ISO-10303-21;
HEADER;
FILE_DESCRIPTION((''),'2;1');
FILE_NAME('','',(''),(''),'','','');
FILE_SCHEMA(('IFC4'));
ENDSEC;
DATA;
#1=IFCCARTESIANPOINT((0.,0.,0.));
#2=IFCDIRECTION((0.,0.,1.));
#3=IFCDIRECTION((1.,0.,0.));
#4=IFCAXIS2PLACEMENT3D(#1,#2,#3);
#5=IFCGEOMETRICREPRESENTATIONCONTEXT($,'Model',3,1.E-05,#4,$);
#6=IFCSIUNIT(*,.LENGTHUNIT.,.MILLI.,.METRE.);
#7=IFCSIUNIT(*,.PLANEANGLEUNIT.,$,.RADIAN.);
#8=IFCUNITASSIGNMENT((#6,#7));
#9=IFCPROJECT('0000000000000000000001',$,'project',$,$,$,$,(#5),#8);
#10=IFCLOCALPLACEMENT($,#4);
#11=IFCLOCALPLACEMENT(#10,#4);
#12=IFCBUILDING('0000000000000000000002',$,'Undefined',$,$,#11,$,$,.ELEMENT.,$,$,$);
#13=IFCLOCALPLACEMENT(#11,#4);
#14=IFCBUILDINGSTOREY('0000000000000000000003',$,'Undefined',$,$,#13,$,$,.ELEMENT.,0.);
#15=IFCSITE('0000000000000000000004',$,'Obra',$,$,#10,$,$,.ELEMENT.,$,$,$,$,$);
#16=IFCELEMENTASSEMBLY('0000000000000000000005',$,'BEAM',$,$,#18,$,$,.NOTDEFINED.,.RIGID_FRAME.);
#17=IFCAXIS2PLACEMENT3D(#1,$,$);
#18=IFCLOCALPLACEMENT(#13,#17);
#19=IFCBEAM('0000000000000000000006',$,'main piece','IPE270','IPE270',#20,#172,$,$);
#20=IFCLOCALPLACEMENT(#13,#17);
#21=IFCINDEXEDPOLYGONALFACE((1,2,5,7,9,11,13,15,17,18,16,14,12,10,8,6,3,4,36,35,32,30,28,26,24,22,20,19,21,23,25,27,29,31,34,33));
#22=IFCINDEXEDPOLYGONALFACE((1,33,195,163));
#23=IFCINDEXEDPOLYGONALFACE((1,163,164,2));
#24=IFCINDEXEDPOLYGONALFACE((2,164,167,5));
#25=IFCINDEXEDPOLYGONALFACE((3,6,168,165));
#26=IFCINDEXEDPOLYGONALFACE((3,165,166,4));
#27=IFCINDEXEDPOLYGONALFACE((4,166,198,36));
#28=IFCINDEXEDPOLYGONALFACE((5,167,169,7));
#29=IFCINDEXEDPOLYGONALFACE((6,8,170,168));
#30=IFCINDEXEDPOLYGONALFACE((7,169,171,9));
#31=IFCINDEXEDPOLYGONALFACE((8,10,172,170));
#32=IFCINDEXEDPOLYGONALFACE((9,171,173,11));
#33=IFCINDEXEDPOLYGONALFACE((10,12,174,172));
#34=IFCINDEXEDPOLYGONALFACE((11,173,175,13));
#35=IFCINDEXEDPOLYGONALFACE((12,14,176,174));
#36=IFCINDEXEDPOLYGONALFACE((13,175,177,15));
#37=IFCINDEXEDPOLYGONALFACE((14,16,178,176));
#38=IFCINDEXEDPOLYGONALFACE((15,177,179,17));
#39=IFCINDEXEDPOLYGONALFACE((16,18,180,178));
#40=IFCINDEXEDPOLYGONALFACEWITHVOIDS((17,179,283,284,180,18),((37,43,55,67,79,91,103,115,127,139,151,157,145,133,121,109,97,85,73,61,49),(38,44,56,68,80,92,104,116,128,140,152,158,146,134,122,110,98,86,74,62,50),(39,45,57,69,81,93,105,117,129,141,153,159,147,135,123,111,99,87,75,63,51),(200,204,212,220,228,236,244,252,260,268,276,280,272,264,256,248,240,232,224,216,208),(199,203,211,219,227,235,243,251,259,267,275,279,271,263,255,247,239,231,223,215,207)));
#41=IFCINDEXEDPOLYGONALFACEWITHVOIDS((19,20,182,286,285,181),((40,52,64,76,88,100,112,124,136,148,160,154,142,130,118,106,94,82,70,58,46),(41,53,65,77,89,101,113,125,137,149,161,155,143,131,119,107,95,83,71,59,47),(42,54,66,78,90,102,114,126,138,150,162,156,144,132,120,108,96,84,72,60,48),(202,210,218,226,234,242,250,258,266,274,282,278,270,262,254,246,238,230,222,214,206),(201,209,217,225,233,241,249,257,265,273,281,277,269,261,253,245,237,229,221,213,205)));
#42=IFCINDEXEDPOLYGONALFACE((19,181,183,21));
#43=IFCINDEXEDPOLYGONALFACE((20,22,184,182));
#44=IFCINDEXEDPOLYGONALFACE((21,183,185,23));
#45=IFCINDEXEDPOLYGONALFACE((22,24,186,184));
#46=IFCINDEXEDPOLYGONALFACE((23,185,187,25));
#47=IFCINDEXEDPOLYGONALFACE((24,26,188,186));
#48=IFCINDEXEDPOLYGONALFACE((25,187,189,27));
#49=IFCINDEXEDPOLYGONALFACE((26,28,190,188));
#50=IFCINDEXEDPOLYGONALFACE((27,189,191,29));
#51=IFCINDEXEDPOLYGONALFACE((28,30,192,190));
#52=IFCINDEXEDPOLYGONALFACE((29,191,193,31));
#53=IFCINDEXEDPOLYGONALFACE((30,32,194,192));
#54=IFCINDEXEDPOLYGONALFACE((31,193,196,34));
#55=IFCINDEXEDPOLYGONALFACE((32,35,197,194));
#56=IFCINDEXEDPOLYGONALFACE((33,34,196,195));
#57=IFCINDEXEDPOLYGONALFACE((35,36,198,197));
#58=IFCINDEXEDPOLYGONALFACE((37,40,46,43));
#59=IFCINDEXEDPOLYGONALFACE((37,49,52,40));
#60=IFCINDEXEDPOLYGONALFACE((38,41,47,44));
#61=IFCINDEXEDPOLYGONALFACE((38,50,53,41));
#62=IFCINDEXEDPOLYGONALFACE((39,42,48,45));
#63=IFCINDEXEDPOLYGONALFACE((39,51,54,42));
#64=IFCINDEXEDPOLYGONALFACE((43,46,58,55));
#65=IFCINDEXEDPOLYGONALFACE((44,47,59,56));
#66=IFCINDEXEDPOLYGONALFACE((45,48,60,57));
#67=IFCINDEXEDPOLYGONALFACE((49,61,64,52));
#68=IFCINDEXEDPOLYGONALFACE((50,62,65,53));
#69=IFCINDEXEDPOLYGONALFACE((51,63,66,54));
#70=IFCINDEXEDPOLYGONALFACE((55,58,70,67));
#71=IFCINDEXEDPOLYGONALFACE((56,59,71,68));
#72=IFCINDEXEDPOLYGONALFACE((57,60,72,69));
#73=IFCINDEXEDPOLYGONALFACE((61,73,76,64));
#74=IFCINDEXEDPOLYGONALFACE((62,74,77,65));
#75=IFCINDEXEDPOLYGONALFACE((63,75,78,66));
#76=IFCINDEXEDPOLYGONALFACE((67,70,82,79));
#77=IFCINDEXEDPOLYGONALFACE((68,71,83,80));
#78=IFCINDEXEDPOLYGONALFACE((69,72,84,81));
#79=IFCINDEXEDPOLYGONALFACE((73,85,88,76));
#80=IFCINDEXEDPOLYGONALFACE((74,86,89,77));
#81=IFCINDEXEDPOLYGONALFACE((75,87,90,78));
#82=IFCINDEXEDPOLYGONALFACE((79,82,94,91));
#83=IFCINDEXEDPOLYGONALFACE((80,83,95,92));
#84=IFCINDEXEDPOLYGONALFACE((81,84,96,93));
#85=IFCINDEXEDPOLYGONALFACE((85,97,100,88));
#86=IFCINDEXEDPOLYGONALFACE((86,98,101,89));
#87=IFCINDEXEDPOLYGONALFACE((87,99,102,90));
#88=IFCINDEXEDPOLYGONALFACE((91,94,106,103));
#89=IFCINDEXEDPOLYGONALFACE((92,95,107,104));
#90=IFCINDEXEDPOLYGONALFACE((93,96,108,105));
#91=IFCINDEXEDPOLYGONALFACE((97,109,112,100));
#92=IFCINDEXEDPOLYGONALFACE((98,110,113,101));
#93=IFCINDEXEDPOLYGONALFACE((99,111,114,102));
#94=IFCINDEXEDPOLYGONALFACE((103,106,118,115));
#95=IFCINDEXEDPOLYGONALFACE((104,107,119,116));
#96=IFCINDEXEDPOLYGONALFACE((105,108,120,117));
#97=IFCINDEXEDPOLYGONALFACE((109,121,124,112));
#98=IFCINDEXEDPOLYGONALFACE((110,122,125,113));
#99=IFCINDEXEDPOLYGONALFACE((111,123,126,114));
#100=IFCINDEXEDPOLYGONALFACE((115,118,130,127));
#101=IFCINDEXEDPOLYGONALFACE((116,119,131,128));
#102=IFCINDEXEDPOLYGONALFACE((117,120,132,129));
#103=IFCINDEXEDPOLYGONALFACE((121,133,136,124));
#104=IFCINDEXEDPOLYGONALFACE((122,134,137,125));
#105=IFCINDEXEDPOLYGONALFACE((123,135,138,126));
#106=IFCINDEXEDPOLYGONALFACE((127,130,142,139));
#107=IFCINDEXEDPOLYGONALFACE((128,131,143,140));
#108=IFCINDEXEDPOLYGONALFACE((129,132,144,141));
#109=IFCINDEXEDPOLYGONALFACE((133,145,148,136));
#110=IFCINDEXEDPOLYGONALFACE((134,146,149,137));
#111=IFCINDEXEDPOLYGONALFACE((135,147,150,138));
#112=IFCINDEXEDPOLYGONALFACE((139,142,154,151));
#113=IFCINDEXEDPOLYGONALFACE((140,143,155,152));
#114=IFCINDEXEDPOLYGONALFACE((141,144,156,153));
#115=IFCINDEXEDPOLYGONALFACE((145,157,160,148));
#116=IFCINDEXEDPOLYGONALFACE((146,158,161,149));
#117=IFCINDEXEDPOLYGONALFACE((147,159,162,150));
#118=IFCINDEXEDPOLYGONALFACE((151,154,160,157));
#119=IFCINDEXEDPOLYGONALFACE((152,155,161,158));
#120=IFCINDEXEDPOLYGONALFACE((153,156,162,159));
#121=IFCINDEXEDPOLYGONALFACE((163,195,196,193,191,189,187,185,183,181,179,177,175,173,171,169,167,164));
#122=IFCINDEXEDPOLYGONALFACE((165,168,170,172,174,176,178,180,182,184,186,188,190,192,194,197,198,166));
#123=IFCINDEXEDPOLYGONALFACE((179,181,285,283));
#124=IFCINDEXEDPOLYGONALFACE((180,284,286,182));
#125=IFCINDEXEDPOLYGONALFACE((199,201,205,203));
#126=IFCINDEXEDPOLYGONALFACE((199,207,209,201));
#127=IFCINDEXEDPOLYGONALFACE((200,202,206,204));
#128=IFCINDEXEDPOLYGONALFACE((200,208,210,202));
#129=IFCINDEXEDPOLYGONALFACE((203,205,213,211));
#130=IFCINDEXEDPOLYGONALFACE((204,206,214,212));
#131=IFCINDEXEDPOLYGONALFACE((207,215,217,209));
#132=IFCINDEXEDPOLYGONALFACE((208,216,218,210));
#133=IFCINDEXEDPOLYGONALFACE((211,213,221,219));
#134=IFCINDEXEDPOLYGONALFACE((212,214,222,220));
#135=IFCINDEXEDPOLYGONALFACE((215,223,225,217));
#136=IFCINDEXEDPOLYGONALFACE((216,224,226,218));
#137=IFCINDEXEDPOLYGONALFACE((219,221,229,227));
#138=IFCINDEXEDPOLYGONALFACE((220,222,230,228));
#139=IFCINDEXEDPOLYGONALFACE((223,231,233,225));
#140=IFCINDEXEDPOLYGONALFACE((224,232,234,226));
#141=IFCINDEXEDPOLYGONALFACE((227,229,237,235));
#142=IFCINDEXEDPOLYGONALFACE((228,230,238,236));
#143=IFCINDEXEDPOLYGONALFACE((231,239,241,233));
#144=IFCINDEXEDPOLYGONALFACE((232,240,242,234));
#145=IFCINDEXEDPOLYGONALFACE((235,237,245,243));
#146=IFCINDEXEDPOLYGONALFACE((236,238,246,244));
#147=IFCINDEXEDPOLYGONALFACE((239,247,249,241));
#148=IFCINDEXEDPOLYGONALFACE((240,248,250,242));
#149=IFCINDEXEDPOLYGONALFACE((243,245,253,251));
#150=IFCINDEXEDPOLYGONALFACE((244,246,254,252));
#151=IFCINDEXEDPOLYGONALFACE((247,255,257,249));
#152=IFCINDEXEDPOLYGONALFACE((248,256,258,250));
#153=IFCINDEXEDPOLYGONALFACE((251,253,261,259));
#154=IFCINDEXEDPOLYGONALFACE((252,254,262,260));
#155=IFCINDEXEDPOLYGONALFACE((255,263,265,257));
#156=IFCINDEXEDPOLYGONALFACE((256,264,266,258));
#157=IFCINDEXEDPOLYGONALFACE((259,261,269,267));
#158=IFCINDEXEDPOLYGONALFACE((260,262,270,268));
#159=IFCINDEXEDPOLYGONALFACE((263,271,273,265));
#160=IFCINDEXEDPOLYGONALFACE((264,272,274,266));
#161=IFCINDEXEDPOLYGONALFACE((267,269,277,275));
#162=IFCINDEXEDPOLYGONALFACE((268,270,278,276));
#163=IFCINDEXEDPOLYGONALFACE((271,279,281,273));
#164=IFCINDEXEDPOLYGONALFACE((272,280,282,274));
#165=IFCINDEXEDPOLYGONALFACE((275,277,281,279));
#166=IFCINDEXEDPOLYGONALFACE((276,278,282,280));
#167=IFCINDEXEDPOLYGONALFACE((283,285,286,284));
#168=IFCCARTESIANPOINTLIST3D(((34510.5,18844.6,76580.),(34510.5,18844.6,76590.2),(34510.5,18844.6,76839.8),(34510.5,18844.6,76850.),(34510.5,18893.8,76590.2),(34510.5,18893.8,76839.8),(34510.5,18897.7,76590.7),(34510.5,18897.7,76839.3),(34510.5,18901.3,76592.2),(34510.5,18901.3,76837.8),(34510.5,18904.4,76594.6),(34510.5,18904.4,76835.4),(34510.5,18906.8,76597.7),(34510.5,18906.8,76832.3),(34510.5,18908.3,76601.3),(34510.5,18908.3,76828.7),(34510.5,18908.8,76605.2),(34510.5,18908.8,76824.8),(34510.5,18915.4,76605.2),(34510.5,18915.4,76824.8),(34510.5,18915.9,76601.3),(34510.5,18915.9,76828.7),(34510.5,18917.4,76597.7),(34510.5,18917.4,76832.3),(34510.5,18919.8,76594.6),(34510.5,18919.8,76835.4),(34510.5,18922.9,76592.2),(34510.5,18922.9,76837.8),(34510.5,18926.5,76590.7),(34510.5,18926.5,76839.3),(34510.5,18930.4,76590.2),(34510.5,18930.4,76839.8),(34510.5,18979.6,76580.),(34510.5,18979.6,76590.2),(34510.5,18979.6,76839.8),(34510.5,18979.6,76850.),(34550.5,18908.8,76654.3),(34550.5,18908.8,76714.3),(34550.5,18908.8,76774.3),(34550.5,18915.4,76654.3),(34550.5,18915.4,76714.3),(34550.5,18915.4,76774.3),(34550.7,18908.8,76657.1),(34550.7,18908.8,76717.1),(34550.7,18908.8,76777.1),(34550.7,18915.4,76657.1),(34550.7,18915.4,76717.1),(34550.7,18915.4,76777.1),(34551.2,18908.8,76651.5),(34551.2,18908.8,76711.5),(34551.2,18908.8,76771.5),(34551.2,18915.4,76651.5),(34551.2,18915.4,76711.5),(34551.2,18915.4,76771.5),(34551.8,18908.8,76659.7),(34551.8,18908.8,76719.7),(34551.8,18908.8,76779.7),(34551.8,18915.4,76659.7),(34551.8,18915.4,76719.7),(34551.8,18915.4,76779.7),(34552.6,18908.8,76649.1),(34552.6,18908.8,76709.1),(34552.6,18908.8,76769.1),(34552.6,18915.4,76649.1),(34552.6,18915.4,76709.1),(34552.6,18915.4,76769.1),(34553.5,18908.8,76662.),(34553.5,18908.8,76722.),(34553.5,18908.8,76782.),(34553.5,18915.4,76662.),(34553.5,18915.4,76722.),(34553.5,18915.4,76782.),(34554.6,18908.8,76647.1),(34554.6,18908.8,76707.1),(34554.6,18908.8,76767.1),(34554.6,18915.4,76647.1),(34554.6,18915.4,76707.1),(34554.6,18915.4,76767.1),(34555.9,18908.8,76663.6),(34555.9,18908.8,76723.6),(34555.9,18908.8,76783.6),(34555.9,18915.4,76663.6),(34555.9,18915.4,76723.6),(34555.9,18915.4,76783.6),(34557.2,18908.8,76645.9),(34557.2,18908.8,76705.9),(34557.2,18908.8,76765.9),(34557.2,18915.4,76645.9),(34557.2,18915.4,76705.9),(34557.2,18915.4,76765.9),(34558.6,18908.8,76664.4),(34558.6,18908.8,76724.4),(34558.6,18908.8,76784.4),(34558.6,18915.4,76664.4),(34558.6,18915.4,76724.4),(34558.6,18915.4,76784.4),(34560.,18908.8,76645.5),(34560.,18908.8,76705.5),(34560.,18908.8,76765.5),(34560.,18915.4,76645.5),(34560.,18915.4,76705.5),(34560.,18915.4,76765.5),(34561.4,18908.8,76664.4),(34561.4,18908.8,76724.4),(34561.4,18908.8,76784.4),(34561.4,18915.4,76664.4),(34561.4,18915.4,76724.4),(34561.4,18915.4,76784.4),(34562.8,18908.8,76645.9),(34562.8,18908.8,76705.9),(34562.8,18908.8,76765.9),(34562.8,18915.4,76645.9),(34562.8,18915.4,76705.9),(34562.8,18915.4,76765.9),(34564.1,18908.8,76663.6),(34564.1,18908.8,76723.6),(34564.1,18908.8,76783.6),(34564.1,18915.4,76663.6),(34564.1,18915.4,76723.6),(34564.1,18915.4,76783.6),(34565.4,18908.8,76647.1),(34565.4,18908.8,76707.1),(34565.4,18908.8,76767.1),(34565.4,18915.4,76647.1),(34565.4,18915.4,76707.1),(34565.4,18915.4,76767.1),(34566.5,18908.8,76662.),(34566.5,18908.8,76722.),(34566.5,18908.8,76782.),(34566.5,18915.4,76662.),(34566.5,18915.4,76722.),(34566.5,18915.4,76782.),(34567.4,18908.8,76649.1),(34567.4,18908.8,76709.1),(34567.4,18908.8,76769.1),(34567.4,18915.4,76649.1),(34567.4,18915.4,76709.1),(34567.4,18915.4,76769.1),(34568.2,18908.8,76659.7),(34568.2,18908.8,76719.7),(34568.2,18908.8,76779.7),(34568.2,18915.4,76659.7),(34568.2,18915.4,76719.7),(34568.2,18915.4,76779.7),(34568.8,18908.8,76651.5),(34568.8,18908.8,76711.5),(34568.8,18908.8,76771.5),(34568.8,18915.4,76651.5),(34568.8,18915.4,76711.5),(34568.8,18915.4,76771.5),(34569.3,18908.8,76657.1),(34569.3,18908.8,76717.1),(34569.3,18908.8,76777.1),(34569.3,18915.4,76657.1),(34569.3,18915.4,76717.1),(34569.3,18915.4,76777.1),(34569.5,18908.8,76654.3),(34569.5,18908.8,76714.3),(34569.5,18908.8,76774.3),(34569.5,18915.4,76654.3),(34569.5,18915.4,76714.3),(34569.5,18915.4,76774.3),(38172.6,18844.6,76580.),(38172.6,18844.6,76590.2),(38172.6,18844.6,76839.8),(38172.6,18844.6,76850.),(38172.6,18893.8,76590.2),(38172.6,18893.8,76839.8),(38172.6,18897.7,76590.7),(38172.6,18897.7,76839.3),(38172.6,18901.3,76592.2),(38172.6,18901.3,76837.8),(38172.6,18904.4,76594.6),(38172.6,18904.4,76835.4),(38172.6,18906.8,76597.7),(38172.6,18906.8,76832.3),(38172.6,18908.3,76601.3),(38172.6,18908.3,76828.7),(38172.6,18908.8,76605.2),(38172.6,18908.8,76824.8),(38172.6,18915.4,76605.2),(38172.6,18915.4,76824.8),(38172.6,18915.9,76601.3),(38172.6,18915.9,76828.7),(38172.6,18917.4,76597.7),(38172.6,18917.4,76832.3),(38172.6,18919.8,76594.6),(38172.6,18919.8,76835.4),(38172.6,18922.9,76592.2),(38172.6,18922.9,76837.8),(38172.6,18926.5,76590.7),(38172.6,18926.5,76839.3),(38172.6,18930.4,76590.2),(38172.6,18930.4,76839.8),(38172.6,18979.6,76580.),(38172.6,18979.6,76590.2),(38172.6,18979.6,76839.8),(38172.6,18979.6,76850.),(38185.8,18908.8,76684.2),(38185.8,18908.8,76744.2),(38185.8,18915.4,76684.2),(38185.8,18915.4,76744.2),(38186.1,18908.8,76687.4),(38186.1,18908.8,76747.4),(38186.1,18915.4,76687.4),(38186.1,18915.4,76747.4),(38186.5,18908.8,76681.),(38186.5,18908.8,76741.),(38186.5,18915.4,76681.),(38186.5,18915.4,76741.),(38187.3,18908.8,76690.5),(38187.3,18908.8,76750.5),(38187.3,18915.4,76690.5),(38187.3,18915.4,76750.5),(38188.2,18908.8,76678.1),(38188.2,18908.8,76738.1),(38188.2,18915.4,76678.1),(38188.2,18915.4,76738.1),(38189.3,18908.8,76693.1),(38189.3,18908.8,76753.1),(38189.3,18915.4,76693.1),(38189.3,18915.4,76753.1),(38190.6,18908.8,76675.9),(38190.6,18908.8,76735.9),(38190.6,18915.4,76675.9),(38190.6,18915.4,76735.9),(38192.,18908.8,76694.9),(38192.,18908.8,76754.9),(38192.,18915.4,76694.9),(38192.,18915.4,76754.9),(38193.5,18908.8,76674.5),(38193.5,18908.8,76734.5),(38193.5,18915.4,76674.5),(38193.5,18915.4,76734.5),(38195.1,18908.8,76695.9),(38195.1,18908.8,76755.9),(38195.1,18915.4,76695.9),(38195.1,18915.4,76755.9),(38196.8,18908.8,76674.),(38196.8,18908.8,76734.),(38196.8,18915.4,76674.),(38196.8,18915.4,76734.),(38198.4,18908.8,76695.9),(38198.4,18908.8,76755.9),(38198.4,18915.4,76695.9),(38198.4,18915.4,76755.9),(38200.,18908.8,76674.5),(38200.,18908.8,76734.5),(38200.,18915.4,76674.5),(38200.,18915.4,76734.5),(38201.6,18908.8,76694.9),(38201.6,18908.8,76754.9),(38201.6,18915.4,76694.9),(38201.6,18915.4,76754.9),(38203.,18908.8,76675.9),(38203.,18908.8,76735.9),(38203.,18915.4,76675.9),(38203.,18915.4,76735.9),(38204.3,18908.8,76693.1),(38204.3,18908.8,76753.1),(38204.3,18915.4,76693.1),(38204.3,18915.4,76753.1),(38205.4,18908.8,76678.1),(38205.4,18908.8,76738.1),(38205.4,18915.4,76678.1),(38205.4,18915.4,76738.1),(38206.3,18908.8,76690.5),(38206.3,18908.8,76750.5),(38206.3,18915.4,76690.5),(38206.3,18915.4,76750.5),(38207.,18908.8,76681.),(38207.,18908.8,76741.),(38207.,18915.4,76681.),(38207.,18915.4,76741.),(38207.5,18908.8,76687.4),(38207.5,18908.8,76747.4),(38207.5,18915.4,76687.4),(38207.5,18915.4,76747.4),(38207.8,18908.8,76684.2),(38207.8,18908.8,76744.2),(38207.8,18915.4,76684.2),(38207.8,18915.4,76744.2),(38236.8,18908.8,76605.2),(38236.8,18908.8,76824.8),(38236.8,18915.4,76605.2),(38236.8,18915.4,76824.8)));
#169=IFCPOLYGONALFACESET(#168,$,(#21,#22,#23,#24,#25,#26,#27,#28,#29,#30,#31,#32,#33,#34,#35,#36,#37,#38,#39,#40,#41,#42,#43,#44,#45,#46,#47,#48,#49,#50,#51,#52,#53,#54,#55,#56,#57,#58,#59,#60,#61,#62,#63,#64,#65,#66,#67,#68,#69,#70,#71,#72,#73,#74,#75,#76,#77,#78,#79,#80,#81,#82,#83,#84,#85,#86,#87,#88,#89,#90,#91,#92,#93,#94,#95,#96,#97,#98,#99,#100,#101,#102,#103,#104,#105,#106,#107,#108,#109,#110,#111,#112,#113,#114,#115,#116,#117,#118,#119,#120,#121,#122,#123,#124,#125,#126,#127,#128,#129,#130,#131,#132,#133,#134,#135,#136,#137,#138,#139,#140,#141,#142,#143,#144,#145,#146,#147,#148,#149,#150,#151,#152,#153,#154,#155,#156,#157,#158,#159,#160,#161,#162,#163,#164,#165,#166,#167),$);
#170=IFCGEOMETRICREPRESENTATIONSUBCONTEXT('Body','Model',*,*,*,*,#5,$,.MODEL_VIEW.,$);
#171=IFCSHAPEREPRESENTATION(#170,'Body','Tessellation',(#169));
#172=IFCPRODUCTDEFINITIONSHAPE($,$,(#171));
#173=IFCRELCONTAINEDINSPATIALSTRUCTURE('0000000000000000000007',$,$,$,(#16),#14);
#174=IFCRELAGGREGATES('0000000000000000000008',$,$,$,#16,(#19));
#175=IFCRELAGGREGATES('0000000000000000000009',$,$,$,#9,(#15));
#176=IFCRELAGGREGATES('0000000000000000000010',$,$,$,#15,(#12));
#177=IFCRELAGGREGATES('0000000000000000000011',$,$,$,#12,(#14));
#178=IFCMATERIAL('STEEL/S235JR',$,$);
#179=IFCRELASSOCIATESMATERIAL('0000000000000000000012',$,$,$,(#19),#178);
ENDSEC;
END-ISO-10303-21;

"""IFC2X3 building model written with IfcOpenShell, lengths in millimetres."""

from ifc_helpers import new_model, si_unit, frame, origin_with_axes, origin_2d_with_axis, place, context, subcontext, project, spatial, rectangle, circle, i_section, extrude, clip, halfspace, source, transform, mapped, material, element, aggregate, save


model = new_model("IFC2X3")

# Units and contexts
model_context = context("Model", 3, precision=1e-05, world=origin_with_axes())
body_context = subcontext(model_context, "Body", "Model", "MODEL_VIEW")
ifc_project = project(units=[si_unit("LENGTHUNIT", "METRE", prefix="MILLI"), si_unit("PLANEANGLEUNIT", "RADIAN")], contexts=[model_context])

# Site, building, storey
site_placement = place(None, origin_with_axes())
site = spatial("IfcSite", under=ifc_project, at=site_placement, Name="Obra", CompositionType="ELEMENT")
building_placement = place(site_placement, origin_with_axes())
building = spatial("IfcBuilding", under=site, at=building_placement, Name="Undefined", CompositionType="ELEMENT")
storey_placement = place(building_placement, origin_with_axes())
storey = spatial("IfcBuildingStorey", under=building, at=storey_placement, Name="Undefined", CompositionType="ELEMENT", Elevation=0.0)

# Shared definitions
ifc_material = material(Name="STEEL/S235JR")

# Element assembly, beam, openings
shared_shape_1 = source(origin_with_axes(), body_context, "Body", "SweptSolid", [
    extrude(circle(Radius=11.0, at=origin_2d_with_axis()), frame((0.0, -3.4, 0.0), z_axis=(0.0, 1.0, 0.0), x_axis=(1.0, 0.0, 0.0)), (0.0, 0.0, 1.0), 6.8),
])
shared_shape_2 = source(origin_with_axes(), body_context, "Body", "SweptSolid", [
    extrude(circle(Radius=9.5, at=origin_2d_with_axis()), frame((0.0, -3.4, 0.0), z_axis=(0.0, 1.0, 0.0), x_axis=(1.0, 0.0, 0.0)), (0.0, 0.0, 1.0), 6.8),
])
assembly_1_placement = place(storey_placement, origin_with_axes())
assembly_1 = element("IfcElementAssembly", 1, at=assembly_1_placement, inside=storey, Name="BEAM", AssemblyPlace="NOTDEFINED", PredefinedType="RIGID_FRAME")
beam_1_placement = place(assembly_1_placement, frame((34251.7, 18912.1, 76715.0), z_axis=(0.0, 0.0, 1.0), x_axis=(1.0, 0.0, 0.0)))
beam_1 = element("IfcBeam", 2, at=beam_1_placement, material=ifc_material, Name="main piece", Description="IPE270", ObjectType="IPE270", context=body_context, shape_type="Clipping", body=[
    clip(clip(extrude(i_section(OverallWidth=135.0, OverallDepth=270.0, WebThickness=6.6, FlangeThickness=10.2, FilletRadius=15.0, at=origin_2d_with_axis()), frame((3985.1, 0.0, 0.0), z_axis=(-1.0, 0.0, 0.0), x_axis=(0.0, -1.0, 0.0)), (0.0, 0.0, 1.0), 3985.1), halfspace(frame((258.8, 60.0, -120.0), z_axis=(-1.0, -0.000019, 0.0), x_axis=(0.0, 0.0, 1.0)), False)), halfspace(frame((3985.1, 0.0, -235.0), z_axis=(-1.0, 0.0, 0.0), x_axis=(0.0, 1.0, 0.0)), True)),
])
opening_1_placement = place(assembly_1_placement, frame((34251.7, 18912.1, 76715.0), z_axis=(0.0, 0.0, 1.0), x_axis=(1.0, 0.0, 0.0)))
element("IfcOpeningElement", 3, at=opening_1_placement, cuts=beam_1, ObjectType="Recess", context=body_context, shape_type="SweptSolid", body=[
    extrude(rectangle(XDim=26.2, YDim=76.2, at=origin_2d_with_axis()), frame((3959.0, 68.5, -122.9), z_axis=(0.0, -1.0, 0.0), x_axis=(0.0, 0.0, -1.0)), (0.0, 0.0, 1.0), 137.0),
])
opening_2_placement = place(assembly_1_placement, frame((34251.7, 18912.1, 76715.0), z_axis=(0.0, 0.0, 1.0), x_axis=(1.0, 0.0, 0.0)))
element("IfcOpeningElement", 4, at=opening_2_placement, cuts=beam_1, ObjectType="Recess", context=body_context, shape_type="SweptSolid", body=[
    extrude(rectangle(XDim=26.2, YDim=76.2, at=origin_2d_with_axis()), frame((3959.0, 68.5, 122.9), z_axis=(0.0, -1.0, 0.0), x_axis=(0.0, 0.0, -1.0)), (0.0, 0.0, 1.0), 137.0),
])
opening_3_placement = place(assembly_1_placement, frame((38236.8, 18912.1, 76850.0), z_axis=(-1.0, 0.0, 0.0), x_axis=(0.0, 0.0, -1.0)))
element("IfcOpeningElement", 5, at=opening_3_placement, cuts=beam_1, ObjectType="Opening", context=body_context, shape_type="MappedRepresentation", body=[
    mapped(shared_shape_1, transform((105.0, 0.0, 40.0))),
    mapped(shared_shape_1, transform((165.0, 0.0, 40.0))),
])
opening_4_placement = place(assembly_1_placement, frame((34510.0, 18912.1, 76835.0), z_axis=(1.0, 0.0, 0.0), x_axis=(0.0, 0.0, -1.0)))
element("IfcOpeningElement", 6, at=opening_4_placement, cuts=beam_1, ObjectType="Opening", context=body_context, shape_type="MappedRepresentation", body=[
    mapped(shared_shape_2, transform((60.0, 0.0, 50.0))),
    mapped(shared_shape_2, transform((120.0, 0.0, 50.0))),
    mapped(shared_shape_2, transform((180.0, 0.0, 50.0))),
])
aggregate(assembly_1, [beam_1])

save(model, "model.ifc")
